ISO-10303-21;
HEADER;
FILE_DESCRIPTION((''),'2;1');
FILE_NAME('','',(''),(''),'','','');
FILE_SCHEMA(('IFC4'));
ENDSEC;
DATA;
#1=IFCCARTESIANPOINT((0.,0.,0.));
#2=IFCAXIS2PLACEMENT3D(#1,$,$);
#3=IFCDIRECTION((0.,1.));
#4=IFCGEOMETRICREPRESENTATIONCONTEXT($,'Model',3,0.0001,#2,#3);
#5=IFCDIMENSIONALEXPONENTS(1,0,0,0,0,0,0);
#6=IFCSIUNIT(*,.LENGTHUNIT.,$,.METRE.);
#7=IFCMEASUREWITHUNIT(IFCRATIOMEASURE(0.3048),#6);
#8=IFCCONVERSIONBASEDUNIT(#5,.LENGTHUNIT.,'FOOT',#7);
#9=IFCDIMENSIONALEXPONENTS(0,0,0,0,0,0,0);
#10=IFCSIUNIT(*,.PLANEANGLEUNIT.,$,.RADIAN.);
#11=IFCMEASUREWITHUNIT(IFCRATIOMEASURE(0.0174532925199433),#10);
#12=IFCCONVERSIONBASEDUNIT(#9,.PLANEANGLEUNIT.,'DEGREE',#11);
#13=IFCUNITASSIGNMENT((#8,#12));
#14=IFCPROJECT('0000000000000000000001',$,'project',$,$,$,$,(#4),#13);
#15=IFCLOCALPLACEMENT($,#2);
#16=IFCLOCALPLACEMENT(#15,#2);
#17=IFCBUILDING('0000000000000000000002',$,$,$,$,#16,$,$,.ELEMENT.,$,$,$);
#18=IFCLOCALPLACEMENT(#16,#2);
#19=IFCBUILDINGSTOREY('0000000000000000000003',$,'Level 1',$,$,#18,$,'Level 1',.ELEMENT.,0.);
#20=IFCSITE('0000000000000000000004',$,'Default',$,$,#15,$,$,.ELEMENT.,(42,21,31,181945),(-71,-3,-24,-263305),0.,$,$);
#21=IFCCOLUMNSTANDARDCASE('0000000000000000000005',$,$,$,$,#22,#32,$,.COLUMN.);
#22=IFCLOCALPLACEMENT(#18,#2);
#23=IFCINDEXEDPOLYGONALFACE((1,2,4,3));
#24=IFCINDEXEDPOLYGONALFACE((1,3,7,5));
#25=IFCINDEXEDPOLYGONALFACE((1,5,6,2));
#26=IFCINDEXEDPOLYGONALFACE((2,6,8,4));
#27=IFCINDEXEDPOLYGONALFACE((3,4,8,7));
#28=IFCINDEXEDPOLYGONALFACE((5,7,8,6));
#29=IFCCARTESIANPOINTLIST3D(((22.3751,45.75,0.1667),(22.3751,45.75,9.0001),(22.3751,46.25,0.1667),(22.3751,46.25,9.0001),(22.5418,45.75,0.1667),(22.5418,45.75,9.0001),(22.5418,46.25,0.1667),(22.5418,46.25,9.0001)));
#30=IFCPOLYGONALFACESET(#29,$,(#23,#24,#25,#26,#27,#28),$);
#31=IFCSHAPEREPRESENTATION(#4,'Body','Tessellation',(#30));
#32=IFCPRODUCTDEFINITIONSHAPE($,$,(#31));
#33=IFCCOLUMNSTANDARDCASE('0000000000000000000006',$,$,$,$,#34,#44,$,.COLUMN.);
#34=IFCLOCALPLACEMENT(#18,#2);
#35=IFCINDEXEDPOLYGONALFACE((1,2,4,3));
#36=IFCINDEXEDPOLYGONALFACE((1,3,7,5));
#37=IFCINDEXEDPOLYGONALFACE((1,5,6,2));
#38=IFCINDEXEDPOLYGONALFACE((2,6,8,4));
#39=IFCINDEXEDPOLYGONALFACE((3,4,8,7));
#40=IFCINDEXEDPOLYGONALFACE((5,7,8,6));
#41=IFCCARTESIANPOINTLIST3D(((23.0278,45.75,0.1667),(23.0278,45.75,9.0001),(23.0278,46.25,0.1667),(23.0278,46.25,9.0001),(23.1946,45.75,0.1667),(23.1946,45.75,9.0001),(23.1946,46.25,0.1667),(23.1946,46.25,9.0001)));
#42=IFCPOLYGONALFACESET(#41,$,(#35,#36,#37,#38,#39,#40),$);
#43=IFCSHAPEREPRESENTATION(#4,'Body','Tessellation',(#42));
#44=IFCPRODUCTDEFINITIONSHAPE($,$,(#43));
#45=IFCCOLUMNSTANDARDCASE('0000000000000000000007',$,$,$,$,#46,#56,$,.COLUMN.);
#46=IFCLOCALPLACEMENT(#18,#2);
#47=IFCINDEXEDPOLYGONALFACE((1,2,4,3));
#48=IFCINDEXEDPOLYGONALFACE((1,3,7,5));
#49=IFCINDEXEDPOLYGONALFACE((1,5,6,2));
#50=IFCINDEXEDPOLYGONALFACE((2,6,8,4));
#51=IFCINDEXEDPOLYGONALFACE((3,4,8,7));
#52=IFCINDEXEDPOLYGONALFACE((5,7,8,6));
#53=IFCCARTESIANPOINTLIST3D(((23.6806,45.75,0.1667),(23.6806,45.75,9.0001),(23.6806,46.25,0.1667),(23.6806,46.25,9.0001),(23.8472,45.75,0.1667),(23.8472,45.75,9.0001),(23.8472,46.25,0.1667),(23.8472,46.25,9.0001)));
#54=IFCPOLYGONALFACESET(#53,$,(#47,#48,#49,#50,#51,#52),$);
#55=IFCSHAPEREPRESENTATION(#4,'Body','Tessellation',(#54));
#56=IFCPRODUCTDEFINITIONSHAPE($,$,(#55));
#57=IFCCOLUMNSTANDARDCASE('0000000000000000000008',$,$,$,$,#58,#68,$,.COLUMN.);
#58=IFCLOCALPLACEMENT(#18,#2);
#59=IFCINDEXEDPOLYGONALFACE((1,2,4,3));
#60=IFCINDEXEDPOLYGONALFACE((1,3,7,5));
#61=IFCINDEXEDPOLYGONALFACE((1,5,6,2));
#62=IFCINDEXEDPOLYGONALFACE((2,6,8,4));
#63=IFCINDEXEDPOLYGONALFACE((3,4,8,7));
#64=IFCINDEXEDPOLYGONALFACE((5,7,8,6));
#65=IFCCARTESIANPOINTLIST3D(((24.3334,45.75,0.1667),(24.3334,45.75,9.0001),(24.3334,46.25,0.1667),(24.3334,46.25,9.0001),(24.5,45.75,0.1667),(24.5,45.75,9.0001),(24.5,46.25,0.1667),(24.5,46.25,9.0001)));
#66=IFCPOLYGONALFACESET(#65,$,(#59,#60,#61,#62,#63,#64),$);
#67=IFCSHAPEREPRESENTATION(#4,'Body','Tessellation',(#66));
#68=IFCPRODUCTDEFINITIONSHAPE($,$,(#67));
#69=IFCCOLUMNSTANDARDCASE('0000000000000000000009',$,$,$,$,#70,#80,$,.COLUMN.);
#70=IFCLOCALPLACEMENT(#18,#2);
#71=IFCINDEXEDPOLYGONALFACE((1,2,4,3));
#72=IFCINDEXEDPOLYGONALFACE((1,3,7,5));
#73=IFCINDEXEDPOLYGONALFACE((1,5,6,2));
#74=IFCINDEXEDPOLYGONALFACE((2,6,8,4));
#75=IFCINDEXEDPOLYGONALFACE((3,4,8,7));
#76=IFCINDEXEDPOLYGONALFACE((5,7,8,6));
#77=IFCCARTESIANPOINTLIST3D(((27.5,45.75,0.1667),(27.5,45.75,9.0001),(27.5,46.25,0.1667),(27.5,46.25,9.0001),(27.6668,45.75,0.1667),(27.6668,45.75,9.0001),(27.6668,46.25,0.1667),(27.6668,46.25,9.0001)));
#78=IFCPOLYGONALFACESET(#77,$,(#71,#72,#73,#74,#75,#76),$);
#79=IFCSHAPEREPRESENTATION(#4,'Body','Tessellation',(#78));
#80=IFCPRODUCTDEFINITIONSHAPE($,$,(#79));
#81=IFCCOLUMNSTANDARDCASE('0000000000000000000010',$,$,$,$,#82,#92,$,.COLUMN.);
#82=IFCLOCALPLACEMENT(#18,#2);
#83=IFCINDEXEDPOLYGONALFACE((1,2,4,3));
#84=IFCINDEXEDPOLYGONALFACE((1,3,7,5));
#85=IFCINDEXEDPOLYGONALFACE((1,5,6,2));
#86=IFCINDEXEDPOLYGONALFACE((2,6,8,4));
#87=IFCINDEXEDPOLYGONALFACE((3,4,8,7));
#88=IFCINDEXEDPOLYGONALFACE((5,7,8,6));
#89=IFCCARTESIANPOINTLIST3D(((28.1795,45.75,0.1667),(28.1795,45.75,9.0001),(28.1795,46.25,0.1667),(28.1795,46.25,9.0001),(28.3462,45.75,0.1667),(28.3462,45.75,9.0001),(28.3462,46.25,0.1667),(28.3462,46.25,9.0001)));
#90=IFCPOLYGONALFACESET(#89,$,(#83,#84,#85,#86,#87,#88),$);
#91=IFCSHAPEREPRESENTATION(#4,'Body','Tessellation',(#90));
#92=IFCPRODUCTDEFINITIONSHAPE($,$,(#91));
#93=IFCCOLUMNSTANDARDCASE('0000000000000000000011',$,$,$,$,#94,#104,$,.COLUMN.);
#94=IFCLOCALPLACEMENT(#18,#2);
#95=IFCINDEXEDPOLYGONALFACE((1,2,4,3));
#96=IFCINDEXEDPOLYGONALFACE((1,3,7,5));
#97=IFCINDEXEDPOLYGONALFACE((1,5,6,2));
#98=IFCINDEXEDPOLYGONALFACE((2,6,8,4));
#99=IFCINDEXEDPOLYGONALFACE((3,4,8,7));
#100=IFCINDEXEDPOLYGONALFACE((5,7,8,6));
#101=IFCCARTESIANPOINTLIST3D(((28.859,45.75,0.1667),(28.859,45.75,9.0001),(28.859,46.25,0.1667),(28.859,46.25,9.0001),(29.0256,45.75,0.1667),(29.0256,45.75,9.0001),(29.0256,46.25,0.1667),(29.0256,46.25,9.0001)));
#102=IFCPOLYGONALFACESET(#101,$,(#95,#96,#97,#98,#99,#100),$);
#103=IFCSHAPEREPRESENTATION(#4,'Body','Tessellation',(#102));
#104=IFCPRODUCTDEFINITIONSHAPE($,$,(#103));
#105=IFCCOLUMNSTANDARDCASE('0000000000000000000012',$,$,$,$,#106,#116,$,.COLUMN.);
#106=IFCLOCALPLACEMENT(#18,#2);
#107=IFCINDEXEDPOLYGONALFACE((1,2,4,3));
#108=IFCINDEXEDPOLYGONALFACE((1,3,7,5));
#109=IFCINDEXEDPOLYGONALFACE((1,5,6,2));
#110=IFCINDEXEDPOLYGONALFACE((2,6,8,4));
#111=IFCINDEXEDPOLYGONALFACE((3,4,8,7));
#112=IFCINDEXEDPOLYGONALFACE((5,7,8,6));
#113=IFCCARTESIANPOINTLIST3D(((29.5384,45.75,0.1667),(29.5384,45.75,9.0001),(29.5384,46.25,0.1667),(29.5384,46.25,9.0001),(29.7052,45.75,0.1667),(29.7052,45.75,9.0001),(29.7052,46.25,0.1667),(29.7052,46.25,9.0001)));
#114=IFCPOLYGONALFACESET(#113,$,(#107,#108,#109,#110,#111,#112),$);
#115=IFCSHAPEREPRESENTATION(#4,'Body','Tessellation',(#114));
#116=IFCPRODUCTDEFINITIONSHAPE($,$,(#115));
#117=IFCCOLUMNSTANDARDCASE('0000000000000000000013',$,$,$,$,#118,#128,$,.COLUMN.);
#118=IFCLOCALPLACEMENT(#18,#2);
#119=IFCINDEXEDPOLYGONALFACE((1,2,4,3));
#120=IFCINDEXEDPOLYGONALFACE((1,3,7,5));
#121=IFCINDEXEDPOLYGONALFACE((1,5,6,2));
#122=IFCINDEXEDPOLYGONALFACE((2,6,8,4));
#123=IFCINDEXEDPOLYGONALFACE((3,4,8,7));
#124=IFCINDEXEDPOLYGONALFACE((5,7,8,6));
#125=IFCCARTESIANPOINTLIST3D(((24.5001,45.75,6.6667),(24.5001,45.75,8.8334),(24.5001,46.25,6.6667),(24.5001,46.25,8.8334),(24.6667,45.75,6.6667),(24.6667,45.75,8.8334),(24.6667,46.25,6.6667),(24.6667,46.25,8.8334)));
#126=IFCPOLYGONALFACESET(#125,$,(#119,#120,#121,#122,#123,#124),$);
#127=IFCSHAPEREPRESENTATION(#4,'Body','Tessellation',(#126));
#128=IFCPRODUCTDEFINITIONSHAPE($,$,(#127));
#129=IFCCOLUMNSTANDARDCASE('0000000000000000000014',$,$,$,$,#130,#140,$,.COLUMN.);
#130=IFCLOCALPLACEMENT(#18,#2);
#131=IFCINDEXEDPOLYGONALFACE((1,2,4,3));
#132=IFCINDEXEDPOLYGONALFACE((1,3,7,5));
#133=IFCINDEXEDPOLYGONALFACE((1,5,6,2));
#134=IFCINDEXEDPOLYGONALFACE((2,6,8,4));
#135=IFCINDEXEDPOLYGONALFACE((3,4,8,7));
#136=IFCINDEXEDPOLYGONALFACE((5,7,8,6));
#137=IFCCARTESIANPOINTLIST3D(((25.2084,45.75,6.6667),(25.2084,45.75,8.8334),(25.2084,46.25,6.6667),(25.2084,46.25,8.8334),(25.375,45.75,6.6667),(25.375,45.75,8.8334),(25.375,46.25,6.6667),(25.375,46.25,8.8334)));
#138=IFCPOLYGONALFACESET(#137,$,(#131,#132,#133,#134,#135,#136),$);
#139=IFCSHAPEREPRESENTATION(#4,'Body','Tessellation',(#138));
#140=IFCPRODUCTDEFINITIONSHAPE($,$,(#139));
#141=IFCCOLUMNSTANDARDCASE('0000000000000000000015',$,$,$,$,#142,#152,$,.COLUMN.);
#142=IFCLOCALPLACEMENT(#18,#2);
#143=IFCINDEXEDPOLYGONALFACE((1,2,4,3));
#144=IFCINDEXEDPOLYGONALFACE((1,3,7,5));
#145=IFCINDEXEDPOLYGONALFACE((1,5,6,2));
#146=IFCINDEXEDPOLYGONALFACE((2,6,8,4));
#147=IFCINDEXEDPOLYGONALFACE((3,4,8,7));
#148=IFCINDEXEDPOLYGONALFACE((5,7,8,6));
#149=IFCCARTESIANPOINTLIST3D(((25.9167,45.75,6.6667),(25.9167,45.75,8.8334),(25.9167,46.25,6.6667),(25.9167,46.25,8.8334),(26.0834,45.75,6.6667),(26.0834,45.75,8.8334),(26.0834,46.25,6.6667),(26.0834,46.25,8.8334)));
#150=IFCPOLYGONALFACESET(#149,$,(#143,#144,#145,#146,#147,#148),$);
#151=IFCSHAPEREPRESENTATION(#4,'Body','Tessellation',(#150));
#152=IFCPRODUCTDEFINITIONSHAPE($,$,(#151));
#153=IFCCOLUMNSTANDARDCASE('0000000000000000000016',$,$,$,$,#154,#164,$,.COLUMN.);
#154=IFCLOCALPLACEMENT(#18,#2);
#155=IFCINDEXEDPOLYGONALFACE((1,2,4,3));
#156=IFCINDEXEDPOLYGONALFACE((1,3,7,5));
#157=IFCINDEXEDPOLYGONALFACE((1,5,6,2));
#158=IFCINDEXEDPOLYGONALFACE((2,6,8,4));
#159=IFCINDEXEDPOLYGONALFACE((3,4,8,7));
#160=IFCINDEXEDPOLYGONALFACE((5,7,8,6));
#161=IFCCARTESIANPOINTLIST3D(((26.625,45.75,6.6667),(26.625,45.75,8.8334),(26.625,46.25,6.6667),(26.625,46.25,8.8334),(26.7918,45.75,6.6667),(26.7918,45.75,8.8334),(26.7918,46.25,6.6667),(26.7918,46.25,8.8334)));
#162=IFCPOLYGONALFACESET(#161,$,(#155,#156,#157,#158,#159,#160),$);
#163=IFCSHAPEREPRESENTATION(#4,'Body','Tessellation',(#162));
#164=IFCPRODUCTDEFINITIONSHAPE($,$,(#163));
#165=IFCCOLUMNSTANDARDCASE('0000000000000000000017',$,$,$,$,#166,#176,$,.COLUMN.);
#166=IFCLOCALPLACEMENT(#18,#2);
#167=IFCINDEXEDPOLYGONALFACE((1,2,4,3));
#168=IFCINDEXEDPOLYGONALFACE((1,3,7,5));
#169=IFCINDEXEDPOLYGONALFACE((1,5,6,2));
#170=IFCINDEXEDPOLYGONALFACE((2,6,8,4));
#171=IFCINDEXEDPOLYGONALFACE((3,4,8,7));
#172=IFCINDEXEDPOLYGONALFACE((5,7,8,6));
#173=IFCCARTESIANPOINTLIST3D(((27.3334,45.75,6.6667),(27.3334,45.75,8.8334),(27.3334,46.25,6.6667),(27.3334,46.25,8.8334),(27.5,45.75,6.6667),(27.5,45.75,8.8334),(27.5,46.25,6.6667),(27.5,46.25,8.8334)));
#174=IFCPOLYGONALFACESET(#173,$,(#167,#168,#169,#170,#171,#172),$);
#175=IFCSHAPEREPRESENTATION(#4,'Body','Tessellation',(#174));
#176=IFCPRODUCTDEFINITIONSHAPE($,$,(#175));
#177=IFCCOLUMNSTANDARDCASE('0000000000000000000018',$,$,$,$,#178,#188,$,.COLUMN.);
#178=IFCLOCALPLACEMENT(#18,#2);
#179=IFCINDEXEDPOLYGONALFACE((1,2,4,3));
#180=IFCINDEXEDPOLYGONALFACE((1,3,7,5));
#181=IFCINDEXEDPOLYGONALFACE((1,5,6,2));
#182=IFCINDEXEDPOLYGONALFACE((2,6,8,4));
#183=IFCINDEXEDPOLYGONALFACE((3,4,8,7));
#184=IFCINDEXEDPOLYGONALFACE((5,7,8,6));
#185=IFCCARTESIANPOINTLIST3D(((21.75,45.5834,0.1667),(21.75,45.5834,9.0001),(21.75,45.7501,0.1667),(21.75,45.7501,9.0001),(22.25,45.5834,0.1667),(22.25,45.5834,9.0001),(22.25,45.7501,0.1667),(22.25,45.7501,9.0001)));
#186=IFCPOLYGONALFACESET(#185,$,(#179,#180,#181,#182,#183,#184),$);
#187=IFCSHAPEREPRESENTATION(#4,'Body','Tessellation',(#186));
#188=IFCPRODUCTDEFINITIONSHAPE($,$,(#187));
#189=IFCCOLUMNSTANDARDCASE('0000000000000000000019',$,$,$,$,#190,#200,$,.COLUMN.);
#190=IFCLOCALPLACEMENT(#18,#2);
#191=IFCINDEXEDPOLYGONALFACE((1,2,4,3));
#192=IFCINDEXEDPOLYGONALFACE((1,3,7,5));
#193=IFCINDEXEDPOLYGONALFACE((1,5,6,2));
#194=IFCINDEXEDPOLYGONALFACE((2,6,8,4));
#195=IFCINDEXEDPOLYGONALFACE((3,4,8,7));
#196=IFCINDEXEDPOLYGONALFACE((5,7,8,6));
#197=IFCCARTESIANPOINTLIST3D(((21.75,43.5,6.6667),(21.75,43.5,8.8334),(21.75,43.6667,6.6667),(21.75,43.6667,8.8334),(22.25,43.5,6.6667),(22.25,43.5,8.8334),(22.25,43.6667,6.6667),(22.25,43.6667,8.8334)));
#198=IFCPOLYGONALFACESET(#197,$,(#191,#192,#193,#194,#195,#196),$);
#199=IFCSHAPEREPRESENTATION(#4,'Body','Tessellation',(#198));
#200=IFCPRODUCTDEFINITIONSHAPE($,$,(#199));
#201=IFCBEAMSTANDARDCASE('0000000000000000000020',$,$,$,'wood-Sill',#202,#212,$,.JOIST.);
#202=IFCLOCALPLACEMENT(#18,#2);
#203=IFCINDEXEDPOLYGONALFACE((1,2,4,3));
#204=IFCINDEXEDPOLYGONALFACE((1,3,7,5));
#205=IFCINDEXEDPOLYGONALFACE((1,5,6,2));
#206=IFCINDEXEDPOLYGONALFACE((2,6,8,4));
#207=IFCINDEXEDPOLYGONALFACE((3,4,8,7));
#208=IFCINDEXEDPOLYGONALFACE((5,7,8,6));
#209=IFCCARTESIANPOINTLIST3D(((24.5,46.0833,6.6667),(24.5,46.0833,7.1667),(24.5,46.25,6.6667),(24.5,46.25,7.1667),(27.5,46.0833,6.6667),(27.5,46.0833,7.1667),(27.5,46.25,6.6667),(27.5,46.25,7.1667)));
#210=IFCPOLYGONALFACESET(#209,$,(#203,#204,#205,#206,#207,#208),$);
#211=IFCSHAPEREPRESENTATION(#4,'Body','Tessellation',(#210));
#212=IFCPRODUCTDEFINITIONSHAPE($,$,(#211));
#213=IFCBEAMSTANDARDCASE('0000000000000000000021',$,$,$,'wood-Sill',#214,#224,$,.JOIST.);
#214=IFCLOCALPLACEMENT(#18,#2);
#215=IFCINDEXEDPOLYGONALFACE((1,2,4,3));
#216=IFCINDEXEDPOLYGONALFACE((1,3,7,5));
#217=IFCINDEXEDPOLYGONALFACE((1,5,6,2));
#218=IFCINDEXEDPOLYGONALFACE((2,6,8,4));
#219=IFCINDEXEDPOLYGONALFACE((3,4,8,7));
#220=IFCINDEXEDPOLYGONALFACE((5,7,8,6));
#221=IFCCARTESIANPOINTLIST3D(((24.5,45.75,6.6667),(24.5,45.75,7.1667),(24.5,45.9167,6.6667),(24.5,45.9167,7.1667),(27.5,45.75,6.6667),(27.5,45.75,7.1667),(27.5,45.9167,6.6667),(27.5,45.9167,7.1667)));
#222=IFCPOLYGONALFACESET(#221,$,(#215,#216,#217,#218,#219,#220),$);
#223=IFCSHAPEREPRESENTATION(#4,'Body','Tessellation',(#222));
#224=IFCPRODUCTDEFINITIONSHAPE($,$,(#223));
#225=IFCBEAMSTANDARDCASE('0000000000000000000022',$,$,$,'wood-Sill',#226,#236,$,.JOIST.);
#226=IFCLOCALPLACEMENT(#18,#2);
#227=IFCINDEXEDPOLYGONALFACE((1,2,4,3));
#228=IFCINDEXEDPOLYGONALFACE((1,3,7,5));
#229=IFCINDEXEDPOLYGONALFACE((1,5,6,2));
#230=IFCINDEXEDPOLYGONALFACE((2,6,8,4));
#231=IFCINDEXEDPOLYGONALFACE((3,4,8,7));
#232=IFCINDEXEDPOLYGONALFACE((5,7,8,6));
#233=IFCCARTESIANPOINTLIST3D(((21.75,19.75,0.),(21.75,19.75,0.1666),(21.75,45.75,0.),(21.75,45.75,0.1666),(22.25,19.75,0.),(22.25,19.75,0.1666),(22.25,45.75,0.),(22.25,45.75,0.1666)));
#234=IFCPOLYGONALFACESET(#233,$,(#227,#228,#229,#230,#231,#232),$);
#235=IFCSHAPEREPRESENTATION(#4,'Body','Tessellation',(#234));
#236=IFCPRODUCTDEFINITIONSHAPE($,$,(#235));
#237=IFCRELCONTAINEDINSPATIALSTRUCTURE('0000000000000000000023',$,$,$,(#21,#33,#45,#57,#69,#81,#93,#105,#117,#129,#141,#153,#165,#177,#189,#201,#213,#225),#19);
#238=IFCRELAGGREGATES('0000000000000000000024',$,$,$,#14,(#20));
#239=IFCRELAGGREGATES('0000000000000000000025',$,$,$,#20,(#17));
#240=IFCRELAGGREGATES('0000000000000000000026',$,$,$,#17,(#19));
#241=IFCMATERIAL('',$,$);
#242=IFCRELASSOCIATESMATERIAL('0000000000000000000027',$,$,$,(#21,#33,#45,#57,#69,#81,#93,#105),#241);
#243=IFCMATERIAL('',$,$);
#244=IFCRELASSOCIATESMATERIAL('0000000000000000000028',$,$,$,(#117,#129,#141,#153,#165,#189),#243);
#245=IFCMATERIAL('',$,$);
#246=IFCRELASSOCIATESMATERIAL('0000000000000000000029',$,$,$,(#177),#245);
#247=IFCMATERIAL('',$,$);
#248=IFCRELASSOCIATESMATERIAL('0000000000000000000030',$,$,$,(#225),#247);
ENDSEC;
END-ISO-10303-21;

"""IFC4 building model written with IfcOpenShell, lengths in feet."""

from ifc_helpers import new_model, entity, si_unit, converted_unit, direction, frame, origin, origin_with_axes, place, context, project, spatial, rectangle, extrude, material, element, save


model = new_model("IFC4")

# Units and contexts
model_context = context("Model", 3, precision=0.0001, world=origin(), true_north=direction((0.0, 1.0)))
ifc_project = project(units=[converted_unit("LENGTHUNIT", "FOOT", entity("IfcRatioMeasure", 0.3048), si_unit("LENGTHUNIT", "METRE"), dimensions=[1, 0, 0, 0, 0, 0, 0]), converted_unit("PLANEANGLEUNIT", "DEGREE", entity("IfcRatioMeasure", 0.0174532925199433), si_unit("PLANEANGLEUNIT", "RADIAN"), dimensions=[0, 0, 0, 0, 0, 0, 0])], contexts=[model_context])

# Site, building, storey
site_placement = place(None, origin())
site = spatial("IfcSite", under=ifc_project, at=site_placement, Name="Default", CompositionType="ELEMENT", RefLatitude=(42, 21, 31, 181945), RefLongitude=(-71, -3, -24, -263305), RefElevation=0.0)
building_placement = place(site_placement, origin())
building = spatial("IfcBuilding", under=site, at=building_placement, CompositionType="ELEMENT")
storey_placement = place(building_placement, origin())
storey = spatial("IfcBuildingStorey", under=building, at=storey_placement, Name="Level 1", LongName="Level 1", CompositionType="ELEMENT", Elevation=0.0)

# Columns
ifc_material_1 = material(Name="")
placement_1 = place(storey_placement, frame((-0.25, 46.0, 0.0)))
for number, where, z_axis, x_axis in (
    (1, (22.7084, 0.0, 0.1667), (0.0, 0.0, 1.0), (1.0, 0.0, 0.0)),
    (2, (23.3612, 0.0, 0.1667), (0.0, 0.0, 1.0), (1.0, 0.0, 0.0)),
    (3, (24.0139, 0.0, 0.1667), (0.0, 0.0, 1.0), (1.0, 0.0, 0.0)),
    (4, (24.6667, 0.0, 0.1667), (0.0, 0.0, 1.0), (1.0, 0.0, 0.0)),
    (5, (27.8334, 0.0, 0.1667), (0.0, 0.0, 1.0), (1.0, 0.0, 0.0)),
    (6, (28.5129, 0.0, 0.1667), (0.0, 0.0, 1.0), (1.0, 0.0, 0.0)),
    (7, (29.1923, 0.0, 0.1667), (0.0, 0.0, 1.0), (1.0, 0.0, 0.0)),
    (8, (29.8718, 0.0, 0.1667), (0.0, 0.0, 1.0), (1.0, 0.0, 0.0)),
):
    element("IfcColumnStandardCase", number, at=place(placement_1, frame(where, z_axis=z_axis, x_axis=x_axis)), inside=storey, material=ifc_material_1, PredefinedType="COLUMN", context=model_context, shape_type="SweptSolid", body=[
        extrude(rectangle(XDim=0.1667, YDim=0.5), origin(), (0.0, 0.0, 1.0), 8.8334),
    ])
ifc_material_2 = material(Name="")
for number, where, z_axis, x_axis in (
    (9, (24.8334, 0.0, 6.6667), (0.0, 0.0, 1.0), (1.0, 0.0, 0.0)),
    (10, (25.5417, 0.0, 6.6667), (0.0, 0.0, 1.0), (1.0, 0.0, 0.0)),
    (11, (26.25, 0.0, 6.6667), (0.0, 0.0, 1.0), (1.0, 0.0, 0.0)),
    (12, (26.9584, 0.0, 6.6667), (0.0, 0.0, 1.0), (1.0, 0.0, 0.0)),
    (13, (27.6667, 0.0, 6.6667), (0.0, 0.0, 1.0), (1.0, 0.0, 0.0)),
):
    element("IfcColumnStandardCase", number, at=place(placement_1, frame(where, z_axis=z_axis, x_axis=x_axis)), inside=storey, material=ifc_material_2, PredefinedType="COLUMN", context=model_context, shape_type="SweptSolid", body=[
        extrude(rectangle(XDim=0.1667, YDim=0.5), origin(), (0.0, 0.0, 1.0), 2.1667),
    ])
ifc_material_3 = material(Name="")
placement_2 = place(storey_placement, frame((22.0, 45.75, 0.0), z_axis=(0.0, 0.0, 1.0), x_axis=(0.0, -1.0, 0.0)))
for number, where, z_axis, x_axis in (
    (14, (0.0833, 0.0, 0.1667), (0.0, 0.0, 1.0), (1.0, 0.0, 0.0)),
):
    element("IfcColumnStandardCase", number, at=place(placement_2, frame(where, z_axis=z_axis, x_axis=x_axis)), inside=storey, material=ifc_material_3, PredefinedType="COLUMN", context=model_context, shape_type="SweptSolid", body=[
        extrude(rectangle(XDim=0.1667, YDim=0.5), origin(), (0.0, 0.0, 1.0), 8.8334),
    ])
for number, where, z_axis, x_axis in (
    (15, (2.1667, 0.0, 6.6667), (0.0, 0.0, 1.0), (1.0, 0.0, 0.0)),
):
    element("IfcColumnStandardCase", number, at=place(placement_2, frame(where, z_axis=z_axis, x_axis=x_axis)), inside=storey, material=ifc_material_2, PredefinedType="COLUMN", context=model_context, shape_type="SweptSolid", body=[
        extrude(rectangle(XDim=0.1667, YDim=0.5), origin(), (0.0, 0.0, 1.0), 2.1667),
    ])

# Beams
for number, where, z_axis, x_axis in (
    (16, (24.75, 0.1667, 6.9167), (1.0, 0.0, 0.0), (0.0, 0.0, 1.0)),
    (17, (24.75, -0.1667, 6.9167), (1.0, 0.0, 0.0), (0.0, 0.0, 1.0)),
):
    element("IfcBeamStandardCase", number, at=place(placement_1, frame(where, z_axis=z_axis, x_axis=x_axis)), inside=storey, ObjectType="wood-Sill", PredefinedType="JOIST", context=model_context, shape_type="SweptSolid", body=[
        extrude(rectangle(XDim=0.5, YDim=0.1667), origin_with_axes(), (0.0, 0.0, 1.0), 3.0),
    ])
ifc_material_4 = material(Name="")
for number, where, z_axis, x_axis in (
    (18, (0.0, 0.0, 0.0833), (1.0, 0.0, 0.0), (0.0, 0.0, 1.0)),
):
    element("IfcBeamStandardCase", number, at=place(placement_2, frame(where, z_axis=z_axis, x_axis=x_axis)), inside=storey, material=ifc_material_4, ObjectType="wood-Sill", PredefinedType="JOIST", context=model_context, shape_type="SweptSolid", body=[
        extrude(rectangle(XDim=0.1667, YDim=0.5), origin_with_axes(), (0.0, 0.0, 1.0), 26.0),
    ])

save(model, "model.ifc")
